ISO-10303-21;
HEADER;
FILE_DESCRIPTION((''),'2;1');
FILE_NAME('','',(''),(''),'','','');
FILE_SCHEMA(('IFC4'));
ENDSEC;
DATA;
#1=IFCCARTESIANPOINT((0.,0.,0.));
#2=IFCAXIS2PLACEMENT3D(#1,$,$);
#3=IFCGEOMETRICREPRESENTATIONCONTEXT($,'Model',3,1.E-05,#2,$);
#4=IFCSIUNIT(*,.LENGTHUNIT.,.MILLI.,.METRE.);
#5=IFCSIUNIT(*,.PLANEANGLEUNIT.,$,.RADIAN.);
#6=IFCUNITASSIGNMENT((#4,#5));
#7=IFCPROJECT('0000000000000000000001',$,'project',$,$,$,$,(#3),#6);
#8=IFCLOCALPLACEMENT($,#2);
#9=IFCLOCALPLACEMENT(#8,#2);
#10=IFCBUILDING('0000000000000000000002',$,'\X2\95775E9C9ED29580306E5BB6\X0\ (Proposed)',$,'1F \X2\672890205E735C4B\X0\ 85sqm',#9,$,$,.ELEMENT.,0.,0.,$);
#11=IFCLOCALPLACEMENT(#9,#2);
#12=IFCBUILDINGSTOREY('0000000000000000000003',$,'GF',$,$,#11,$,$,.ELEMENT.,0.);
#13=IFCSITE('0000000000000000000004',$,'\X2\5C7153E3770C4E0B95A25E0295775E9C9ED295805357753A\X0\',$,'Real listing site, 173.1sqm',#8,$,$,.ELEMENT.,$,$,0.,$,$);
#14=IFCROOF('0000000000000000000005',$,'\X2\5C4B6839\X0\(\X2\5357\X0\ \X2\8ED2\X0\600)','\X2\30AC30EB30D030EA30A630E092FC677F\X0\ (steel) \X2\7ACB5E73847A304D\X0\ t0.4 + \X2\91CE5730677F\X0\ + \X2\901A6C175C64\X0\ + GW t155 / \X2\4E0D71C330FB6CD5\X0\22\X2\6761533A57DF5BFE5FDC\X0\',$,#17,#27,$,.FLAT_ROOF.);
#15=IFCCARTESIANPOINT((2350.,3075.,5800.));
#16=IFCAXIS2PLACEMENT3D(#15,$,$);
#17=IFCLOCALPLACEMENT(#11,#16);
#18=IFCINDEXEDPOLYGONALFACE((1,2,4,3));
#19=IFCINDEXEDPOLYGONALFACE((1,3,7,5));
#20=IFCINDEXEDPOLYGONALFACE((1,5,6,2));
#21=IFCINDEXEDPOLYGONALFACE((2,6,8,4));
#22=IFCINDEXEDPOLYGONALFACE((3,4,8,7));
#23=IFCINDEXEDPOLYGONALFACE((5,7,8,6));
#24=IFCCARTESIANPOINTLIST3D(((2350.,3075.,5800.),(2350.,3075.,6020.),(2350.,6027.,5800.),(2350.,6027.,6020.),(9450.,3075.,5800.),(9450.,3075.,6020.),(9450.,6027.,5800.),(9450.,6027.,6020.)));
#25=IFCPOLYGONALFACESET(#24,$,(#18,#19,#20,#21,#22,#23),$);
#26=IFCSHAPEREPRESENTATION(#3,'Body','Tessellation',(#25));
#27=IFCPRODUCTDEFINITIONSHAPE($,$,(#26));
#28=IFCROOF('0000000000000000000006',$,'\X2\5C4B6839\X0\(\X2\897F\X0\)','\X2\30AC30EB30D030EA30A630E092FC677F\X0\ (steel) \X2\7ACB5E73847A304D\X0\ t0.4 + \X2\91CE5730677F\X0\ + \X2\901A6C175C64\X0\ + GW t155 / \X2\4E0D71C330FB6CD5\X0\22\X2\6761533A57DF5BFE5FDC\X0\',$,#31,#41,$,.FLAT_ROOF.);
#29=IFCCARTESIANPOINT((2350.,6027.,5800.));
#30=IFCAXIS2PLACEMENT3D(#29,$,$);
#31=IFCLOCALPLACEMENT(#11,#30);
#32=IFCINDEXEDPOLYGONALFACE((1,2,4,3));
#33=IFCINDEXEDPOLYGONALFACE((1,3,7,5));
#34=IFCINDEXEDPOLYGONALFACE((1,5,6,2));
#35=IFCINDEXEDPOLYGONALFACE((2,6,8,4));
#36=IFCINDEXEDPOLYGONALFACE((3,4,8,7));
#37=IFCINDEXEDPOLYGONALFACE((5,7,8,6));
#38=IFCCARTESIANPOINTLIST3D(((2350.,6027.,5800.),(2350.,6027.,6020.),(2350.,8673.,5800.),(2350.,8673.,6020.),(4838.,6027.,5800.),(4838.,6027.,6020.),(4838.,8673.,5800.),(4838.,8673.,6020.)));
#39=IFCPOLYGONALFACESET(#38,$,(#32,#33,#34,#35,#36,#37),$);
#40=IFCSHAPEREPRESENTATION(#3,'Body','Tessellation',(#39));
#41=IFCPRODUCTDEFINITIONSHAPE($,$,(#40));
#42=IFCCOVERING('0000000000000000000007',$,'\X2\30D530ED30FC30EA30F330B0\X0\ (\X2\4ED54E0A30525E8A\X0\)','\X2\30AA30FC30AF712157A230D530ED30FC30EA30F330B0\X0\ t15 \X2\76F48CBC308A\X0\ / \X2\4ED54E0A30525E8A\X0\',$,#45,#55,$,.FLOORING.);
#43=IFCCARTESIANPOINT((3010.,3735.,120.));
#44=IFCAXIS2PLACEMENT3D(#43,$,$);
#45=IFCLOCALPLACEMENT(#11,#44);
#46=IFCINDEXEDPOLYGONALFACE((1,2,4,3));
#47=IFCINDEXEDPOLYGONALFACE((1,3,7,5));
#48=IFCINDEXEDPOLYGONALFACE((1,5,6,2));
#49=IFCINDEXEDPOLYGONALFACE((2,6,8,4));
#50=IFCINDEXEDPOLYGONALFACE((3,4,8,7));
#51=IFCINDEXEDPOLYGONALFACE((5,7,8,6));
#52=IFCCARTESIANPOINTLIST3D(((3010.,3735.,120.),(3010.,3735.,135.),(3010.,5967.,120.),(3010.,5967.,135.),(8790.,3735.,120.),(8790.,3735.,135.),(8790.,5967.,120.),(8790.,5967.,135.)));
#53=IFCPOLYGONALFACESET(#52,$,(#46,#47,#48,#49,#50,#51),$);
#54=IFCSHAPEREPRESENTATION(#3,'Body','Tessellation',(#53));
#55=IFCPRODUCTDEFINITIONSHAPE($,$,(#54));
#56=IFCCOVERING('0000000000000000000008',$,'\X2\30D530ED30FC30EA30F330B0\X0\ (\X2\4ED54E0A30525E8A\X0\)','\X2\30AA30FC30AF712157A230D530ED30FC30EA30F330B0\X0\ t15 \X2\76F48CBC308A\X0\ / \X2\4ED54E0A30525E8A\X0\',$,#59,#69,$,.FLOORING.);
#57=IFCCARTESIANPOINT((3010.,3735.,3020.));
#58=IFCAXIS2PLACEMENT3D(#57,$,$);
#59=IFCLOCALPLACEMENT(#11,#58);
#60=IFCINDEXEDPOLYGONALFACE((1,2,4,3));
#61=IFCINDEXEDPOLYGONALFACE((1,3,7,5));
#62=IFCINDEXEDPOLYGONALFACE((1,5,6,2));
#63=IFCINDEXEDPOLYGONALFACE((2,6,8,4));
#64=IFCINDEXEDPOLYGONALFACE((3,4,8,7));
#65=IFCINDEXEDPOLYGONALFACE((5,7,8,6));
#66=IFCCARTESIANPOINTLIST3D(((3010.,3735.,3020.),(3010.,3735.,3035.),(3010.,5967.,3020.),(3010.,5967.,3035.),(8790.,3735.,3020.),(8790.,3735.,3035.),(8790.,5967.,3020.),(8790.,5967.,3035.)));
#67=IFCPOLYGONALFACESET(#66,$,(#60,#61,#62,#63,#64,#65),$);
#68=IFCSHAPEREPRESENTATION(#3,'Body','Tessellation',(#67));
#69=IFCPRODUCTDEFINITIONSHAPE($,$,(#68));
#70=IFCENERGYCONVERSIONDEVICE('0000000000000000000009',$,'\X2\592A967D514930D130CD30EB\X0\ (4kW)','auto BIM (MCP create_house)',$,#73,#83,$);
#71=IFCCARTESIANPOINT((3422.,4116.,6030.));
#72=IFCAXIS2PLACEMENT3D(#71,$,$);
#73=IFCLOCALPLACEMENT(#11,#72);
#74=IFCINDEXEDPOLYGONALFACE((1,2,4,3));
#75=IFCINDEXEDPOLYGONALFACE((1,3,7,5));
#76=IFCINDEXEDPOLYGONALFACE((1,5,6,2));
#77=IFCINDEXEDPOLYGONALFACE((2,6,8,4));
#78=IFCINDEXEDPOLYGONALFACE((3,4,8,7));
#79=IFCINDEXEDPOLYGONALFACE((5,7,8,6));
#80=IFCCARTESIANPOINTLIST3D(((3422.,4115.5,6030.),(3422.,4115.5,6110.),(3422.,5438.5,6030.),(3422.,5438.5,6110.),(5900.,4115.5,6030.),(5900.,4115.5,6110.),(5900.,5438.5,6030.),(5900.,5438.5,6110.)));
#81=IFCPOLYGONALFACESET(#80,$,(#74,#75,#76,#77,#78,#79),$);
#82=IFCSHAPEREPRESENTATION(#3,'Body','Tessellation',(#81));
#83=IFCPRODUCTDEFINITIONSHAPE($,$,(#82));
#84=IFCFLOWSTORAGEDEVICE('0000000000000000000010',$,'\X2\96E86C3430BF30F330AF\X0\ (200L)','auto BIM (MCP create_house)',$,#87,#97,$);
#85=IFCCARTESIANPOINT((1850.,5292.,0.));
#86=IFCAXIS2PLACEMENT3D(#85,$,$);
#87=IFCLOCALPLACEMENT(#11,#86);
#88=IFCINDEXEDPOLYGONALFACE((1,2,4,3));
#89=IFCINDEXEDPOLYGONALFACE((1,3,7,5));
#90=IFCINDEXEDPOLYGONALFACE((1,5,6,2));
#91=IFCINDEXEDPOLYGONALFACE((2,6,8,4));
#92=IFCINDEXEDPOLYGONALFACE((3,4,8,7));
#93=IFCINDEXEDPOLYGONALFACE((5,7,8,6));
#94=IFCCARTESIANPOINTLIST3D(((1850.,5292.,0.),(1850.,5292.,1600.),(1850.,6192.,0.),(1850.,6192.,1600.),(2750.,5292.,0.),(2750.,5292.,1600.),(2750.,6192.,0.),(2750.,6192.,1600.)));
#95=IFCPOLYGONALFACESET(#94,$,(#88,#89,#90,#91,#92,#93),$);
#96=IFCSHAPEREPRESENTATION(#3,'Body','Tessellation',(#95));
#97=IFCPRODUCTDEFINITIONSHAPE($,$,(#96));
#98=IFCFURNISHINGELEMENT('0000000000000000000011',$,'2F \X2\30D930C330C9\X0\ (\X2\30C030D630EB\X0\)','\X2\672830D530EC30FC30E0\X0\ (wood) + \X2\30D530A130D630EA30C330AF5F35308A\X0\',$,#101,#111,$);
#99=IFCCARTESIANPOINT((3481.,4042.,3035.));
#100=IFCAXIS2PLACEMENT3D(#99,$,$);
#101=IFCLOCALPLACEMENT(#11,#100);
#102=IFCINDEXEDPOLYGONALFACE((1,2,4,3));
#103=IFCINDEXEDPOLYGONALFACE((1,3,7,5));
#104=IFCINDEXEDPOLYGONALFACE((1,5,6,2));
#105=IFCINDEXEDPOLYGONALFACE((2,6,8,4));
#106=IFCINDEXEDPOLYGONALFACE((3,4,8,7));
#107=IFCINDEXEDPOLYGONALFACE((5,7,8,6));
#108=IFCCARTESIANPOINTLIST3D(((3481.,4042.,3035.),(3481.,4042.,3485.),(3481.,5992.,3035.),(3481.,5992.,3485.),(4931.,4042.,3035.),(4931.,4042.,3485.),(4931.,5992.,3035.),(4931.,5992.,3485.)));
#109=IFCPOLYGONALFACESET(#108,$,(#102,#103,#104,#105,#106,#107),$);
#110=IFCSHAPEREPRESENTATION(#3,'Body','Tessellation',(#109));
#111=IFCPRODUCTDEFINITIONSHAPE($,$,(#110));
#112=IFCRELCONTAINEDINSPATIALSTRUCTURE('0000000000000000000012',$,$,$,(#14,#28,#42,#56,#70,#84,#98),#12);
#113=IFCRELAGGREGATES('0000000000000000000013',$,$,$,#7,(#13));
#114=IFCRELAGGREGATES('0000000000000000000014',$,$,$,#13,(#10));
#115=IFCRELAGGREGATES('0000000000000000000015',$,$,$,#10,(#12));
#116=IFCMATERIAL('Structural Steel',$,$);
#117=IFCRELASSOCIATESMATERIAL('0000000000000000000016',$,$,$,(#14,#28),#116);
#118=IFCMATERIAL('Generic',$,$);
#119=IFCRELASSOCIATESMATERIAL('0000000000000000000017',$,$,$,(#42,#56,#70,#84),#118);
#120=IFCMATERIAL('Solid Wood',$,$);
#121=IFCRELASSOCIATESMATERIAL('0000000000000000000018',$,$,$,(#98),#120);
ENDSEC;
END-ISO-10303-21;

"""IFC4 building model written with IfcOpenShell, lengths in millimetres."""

from ifc_helpers import new_model, si_unit, frame, frame_2d, origin, place, context, project, spatial, rectangle, extrude, material, element, save


model = new_model("IFC4")

# Units and contexts
model_context = context("Model", 3, precision=1e-05, world=origin())
ifc_project = project(units=[si_unit("LENGTHUNIT", "METRE", prefix="MILLI"), si_unit("PLANEANGLEUNIT", "RADIAN")], contexts=[model_context])

# Site, building, storey
site_placement = place(None, origin())
site = spatial("IfcSite", under=ifc_project, at=site_placement, Name="山口県下関市長府黒門南町", ObjectType="Real listing site, 173.1sqm", CompositionType="ELEMENT", RefElevation=0.0)
building_placement = place(site_placement, origin())
building = spatial("IfcBuilding", under=site, at=building_placement, Name="長府黒門の家 (Proposed)", ObjectType="1F 木造平屋 85sqm", CompositionType="ELEMENT", ElevationOfRefHeight=0.0, ElevationOfTerrain=0.0)
storey_placement = place(building_placement, origin())
storey = spatial("IfcBuildingStorey", under=building, at=storey_placement, Name="GF", CompositionType="ELEMENT", Elevation=0.0)

# Shared definitions
ifc_material_1 = material(Name="Solid Wood")
ifc_material_2 = material(Name="Generic")

# Roofs
ifc_material_3 = material(Name="Structural Steel")
roof_1_placement = place(storey_placement, frame((2350.0, 3075.0, 5800.0)))
element("IfcRoof", 1, at=roof_1_placement, inside=storey, material=ifc_material_3, Name="屋根(南 軒600)", Description="ガルバリウム鋼板 (steel) 立平葺き t0.4 + 野地板 + 通気層 + GW t155 / 不燃・法22条区域対応", PredefinedType="FLAT_ROOF", context=model_context, shape_type="SweptSolid", body=[
    extrude(rectangle(XDim=7100.0, YDim=2952.0, at=frame_2d((3550.0, 1476.0))), frame((2350.0, 3075.0, 5800.0)), (0.0, 0.0, 1.0), 220.0),
])
roof_2_placement = place(storey_placement, frame((2350.0, 6027.0, 5800.0)))
element("IfcRoof", 2, at=roof_2_placement, inside=storey, material=ifc_material_3, Name="屋根(西)", Description="ガルバリウム鋼板 (steel) 立平葺き t0.4 + 野地板 + 通気層 + GW t155 / 不燃・法22条区域対応", PredefinedType="FLAT_ROOF", context=model_context, shape_type="SweptSolid", body=[
    extrude(rectangle(XDim=2488.0, YDim=2646.0, at=frame_2d((1244.0, 1323.0))), frame((2350.0, 6027.0, 5800.0)), (0.0, 0.0, 1.0), 220.0),
])

# Coverings
covering_1_placement = place(storey_placement, frame((3010.0, 3735.0, 120.0)))
element("IfcCovering", 3, at=covering_1_placement, inside=storey, material=ifc_material_2, Name="フローリング (仕上げ床)", Description="オーク無垢フローリング t15 直貼り / 仕上げ床", PredefinedType="FLOORING", context=model_context, shape_type="SweptSolid", body=[
    extrude(rectangle(XDim=5780.0, YDim=2232.0, at=frame_2d((2890.0, 1116.0))), frame((3010.0, 3735.0, 120.0)), (0.0, 0.0, 1.0), 15.0),
])
covering_2_placement = place(storey_placement, frame((3010.0, 3735.0, 3020.0)))
element("IfcCovering", 4, at=covering_2_placement, inside=storey, material=ifc_material_2, Name="フローリング (仕上げ床)", Description="オーク無垢フローリング t15 直貼り / 仕上げ床", PredefinedType="FLOORING", context=model_context, shape_type="SweptSolid", body=[
    extrude(rectangle(XDim=5780.0, YDim=2232.0, at=frame_2d((2890.0, 1116.0))), frame((3010.0, 3735.0, 3020.0)), (0.0, 0.0, 1.0), 15.0),
])

# Energy conversion device
energy_conversion_device_placement = place(storey_placement, frame((3422.0, 4116.0, 6030.0)))
element("IfcEnergyConversionDevice", 5, at=energy_conversion_device_placement, inside=storey, material=ifc_material_2, Name="太陽光パネル (4kW)", Description="auto BIM (MCP create_house)", context=model_context, shape_type="SweptSolid", body=[
    extrude(rectangle(XDim=2478.0, YDim=1323.0, at=frame_2d((1239.0, 661.0))), frame((3422.0, 4116.0, 6030.0)), (0.0, 0.0, 1.0), 80.0),
])

# Flow storage device
flow_storage_device_placement = place(storey_placement, frame((1850.0, 5292.0, 0.0)))
element("IfcFlowStorageDevice", 6, at=flow_storage_device_placement, inside=storey, material=ifc_material_2, Name="雨水タンク (200L)", Description="auto BIM (MCP create_house)", context=model_context, shape_type="SweptSolid", body=[
    extrude(rectangle(XDim=900.0, YDim=900.0, at=frame_2d((450.0, 450.0))), frame((1850.0, 5292.0, 0.0)), (0.0, 0.0, 1.0), 1600.0),
])

# Furnishing element
furnishing_placement = place(storey_placement, frame((3481.0, 4042.0, 3035.0)))
element("IfcFurnishingElement", 7, at=furnishing_placement, inside=storey, material=ifc_material_1, Name="2F ベッド (ダブル)", Description="木フレーム (wood) + ファブリック張り", context=model_context, shape_type="SweptSolid", body=[
    extrude(rectangle(XDim=1450.0, YDim=1950.0, at=frame_2d((725.0, 975.0))), frame((3481.0, 4042.0, 3035.0)), (0.0, 0.0, 1.0), 450.0),
])

save(model, "model.ifc")
